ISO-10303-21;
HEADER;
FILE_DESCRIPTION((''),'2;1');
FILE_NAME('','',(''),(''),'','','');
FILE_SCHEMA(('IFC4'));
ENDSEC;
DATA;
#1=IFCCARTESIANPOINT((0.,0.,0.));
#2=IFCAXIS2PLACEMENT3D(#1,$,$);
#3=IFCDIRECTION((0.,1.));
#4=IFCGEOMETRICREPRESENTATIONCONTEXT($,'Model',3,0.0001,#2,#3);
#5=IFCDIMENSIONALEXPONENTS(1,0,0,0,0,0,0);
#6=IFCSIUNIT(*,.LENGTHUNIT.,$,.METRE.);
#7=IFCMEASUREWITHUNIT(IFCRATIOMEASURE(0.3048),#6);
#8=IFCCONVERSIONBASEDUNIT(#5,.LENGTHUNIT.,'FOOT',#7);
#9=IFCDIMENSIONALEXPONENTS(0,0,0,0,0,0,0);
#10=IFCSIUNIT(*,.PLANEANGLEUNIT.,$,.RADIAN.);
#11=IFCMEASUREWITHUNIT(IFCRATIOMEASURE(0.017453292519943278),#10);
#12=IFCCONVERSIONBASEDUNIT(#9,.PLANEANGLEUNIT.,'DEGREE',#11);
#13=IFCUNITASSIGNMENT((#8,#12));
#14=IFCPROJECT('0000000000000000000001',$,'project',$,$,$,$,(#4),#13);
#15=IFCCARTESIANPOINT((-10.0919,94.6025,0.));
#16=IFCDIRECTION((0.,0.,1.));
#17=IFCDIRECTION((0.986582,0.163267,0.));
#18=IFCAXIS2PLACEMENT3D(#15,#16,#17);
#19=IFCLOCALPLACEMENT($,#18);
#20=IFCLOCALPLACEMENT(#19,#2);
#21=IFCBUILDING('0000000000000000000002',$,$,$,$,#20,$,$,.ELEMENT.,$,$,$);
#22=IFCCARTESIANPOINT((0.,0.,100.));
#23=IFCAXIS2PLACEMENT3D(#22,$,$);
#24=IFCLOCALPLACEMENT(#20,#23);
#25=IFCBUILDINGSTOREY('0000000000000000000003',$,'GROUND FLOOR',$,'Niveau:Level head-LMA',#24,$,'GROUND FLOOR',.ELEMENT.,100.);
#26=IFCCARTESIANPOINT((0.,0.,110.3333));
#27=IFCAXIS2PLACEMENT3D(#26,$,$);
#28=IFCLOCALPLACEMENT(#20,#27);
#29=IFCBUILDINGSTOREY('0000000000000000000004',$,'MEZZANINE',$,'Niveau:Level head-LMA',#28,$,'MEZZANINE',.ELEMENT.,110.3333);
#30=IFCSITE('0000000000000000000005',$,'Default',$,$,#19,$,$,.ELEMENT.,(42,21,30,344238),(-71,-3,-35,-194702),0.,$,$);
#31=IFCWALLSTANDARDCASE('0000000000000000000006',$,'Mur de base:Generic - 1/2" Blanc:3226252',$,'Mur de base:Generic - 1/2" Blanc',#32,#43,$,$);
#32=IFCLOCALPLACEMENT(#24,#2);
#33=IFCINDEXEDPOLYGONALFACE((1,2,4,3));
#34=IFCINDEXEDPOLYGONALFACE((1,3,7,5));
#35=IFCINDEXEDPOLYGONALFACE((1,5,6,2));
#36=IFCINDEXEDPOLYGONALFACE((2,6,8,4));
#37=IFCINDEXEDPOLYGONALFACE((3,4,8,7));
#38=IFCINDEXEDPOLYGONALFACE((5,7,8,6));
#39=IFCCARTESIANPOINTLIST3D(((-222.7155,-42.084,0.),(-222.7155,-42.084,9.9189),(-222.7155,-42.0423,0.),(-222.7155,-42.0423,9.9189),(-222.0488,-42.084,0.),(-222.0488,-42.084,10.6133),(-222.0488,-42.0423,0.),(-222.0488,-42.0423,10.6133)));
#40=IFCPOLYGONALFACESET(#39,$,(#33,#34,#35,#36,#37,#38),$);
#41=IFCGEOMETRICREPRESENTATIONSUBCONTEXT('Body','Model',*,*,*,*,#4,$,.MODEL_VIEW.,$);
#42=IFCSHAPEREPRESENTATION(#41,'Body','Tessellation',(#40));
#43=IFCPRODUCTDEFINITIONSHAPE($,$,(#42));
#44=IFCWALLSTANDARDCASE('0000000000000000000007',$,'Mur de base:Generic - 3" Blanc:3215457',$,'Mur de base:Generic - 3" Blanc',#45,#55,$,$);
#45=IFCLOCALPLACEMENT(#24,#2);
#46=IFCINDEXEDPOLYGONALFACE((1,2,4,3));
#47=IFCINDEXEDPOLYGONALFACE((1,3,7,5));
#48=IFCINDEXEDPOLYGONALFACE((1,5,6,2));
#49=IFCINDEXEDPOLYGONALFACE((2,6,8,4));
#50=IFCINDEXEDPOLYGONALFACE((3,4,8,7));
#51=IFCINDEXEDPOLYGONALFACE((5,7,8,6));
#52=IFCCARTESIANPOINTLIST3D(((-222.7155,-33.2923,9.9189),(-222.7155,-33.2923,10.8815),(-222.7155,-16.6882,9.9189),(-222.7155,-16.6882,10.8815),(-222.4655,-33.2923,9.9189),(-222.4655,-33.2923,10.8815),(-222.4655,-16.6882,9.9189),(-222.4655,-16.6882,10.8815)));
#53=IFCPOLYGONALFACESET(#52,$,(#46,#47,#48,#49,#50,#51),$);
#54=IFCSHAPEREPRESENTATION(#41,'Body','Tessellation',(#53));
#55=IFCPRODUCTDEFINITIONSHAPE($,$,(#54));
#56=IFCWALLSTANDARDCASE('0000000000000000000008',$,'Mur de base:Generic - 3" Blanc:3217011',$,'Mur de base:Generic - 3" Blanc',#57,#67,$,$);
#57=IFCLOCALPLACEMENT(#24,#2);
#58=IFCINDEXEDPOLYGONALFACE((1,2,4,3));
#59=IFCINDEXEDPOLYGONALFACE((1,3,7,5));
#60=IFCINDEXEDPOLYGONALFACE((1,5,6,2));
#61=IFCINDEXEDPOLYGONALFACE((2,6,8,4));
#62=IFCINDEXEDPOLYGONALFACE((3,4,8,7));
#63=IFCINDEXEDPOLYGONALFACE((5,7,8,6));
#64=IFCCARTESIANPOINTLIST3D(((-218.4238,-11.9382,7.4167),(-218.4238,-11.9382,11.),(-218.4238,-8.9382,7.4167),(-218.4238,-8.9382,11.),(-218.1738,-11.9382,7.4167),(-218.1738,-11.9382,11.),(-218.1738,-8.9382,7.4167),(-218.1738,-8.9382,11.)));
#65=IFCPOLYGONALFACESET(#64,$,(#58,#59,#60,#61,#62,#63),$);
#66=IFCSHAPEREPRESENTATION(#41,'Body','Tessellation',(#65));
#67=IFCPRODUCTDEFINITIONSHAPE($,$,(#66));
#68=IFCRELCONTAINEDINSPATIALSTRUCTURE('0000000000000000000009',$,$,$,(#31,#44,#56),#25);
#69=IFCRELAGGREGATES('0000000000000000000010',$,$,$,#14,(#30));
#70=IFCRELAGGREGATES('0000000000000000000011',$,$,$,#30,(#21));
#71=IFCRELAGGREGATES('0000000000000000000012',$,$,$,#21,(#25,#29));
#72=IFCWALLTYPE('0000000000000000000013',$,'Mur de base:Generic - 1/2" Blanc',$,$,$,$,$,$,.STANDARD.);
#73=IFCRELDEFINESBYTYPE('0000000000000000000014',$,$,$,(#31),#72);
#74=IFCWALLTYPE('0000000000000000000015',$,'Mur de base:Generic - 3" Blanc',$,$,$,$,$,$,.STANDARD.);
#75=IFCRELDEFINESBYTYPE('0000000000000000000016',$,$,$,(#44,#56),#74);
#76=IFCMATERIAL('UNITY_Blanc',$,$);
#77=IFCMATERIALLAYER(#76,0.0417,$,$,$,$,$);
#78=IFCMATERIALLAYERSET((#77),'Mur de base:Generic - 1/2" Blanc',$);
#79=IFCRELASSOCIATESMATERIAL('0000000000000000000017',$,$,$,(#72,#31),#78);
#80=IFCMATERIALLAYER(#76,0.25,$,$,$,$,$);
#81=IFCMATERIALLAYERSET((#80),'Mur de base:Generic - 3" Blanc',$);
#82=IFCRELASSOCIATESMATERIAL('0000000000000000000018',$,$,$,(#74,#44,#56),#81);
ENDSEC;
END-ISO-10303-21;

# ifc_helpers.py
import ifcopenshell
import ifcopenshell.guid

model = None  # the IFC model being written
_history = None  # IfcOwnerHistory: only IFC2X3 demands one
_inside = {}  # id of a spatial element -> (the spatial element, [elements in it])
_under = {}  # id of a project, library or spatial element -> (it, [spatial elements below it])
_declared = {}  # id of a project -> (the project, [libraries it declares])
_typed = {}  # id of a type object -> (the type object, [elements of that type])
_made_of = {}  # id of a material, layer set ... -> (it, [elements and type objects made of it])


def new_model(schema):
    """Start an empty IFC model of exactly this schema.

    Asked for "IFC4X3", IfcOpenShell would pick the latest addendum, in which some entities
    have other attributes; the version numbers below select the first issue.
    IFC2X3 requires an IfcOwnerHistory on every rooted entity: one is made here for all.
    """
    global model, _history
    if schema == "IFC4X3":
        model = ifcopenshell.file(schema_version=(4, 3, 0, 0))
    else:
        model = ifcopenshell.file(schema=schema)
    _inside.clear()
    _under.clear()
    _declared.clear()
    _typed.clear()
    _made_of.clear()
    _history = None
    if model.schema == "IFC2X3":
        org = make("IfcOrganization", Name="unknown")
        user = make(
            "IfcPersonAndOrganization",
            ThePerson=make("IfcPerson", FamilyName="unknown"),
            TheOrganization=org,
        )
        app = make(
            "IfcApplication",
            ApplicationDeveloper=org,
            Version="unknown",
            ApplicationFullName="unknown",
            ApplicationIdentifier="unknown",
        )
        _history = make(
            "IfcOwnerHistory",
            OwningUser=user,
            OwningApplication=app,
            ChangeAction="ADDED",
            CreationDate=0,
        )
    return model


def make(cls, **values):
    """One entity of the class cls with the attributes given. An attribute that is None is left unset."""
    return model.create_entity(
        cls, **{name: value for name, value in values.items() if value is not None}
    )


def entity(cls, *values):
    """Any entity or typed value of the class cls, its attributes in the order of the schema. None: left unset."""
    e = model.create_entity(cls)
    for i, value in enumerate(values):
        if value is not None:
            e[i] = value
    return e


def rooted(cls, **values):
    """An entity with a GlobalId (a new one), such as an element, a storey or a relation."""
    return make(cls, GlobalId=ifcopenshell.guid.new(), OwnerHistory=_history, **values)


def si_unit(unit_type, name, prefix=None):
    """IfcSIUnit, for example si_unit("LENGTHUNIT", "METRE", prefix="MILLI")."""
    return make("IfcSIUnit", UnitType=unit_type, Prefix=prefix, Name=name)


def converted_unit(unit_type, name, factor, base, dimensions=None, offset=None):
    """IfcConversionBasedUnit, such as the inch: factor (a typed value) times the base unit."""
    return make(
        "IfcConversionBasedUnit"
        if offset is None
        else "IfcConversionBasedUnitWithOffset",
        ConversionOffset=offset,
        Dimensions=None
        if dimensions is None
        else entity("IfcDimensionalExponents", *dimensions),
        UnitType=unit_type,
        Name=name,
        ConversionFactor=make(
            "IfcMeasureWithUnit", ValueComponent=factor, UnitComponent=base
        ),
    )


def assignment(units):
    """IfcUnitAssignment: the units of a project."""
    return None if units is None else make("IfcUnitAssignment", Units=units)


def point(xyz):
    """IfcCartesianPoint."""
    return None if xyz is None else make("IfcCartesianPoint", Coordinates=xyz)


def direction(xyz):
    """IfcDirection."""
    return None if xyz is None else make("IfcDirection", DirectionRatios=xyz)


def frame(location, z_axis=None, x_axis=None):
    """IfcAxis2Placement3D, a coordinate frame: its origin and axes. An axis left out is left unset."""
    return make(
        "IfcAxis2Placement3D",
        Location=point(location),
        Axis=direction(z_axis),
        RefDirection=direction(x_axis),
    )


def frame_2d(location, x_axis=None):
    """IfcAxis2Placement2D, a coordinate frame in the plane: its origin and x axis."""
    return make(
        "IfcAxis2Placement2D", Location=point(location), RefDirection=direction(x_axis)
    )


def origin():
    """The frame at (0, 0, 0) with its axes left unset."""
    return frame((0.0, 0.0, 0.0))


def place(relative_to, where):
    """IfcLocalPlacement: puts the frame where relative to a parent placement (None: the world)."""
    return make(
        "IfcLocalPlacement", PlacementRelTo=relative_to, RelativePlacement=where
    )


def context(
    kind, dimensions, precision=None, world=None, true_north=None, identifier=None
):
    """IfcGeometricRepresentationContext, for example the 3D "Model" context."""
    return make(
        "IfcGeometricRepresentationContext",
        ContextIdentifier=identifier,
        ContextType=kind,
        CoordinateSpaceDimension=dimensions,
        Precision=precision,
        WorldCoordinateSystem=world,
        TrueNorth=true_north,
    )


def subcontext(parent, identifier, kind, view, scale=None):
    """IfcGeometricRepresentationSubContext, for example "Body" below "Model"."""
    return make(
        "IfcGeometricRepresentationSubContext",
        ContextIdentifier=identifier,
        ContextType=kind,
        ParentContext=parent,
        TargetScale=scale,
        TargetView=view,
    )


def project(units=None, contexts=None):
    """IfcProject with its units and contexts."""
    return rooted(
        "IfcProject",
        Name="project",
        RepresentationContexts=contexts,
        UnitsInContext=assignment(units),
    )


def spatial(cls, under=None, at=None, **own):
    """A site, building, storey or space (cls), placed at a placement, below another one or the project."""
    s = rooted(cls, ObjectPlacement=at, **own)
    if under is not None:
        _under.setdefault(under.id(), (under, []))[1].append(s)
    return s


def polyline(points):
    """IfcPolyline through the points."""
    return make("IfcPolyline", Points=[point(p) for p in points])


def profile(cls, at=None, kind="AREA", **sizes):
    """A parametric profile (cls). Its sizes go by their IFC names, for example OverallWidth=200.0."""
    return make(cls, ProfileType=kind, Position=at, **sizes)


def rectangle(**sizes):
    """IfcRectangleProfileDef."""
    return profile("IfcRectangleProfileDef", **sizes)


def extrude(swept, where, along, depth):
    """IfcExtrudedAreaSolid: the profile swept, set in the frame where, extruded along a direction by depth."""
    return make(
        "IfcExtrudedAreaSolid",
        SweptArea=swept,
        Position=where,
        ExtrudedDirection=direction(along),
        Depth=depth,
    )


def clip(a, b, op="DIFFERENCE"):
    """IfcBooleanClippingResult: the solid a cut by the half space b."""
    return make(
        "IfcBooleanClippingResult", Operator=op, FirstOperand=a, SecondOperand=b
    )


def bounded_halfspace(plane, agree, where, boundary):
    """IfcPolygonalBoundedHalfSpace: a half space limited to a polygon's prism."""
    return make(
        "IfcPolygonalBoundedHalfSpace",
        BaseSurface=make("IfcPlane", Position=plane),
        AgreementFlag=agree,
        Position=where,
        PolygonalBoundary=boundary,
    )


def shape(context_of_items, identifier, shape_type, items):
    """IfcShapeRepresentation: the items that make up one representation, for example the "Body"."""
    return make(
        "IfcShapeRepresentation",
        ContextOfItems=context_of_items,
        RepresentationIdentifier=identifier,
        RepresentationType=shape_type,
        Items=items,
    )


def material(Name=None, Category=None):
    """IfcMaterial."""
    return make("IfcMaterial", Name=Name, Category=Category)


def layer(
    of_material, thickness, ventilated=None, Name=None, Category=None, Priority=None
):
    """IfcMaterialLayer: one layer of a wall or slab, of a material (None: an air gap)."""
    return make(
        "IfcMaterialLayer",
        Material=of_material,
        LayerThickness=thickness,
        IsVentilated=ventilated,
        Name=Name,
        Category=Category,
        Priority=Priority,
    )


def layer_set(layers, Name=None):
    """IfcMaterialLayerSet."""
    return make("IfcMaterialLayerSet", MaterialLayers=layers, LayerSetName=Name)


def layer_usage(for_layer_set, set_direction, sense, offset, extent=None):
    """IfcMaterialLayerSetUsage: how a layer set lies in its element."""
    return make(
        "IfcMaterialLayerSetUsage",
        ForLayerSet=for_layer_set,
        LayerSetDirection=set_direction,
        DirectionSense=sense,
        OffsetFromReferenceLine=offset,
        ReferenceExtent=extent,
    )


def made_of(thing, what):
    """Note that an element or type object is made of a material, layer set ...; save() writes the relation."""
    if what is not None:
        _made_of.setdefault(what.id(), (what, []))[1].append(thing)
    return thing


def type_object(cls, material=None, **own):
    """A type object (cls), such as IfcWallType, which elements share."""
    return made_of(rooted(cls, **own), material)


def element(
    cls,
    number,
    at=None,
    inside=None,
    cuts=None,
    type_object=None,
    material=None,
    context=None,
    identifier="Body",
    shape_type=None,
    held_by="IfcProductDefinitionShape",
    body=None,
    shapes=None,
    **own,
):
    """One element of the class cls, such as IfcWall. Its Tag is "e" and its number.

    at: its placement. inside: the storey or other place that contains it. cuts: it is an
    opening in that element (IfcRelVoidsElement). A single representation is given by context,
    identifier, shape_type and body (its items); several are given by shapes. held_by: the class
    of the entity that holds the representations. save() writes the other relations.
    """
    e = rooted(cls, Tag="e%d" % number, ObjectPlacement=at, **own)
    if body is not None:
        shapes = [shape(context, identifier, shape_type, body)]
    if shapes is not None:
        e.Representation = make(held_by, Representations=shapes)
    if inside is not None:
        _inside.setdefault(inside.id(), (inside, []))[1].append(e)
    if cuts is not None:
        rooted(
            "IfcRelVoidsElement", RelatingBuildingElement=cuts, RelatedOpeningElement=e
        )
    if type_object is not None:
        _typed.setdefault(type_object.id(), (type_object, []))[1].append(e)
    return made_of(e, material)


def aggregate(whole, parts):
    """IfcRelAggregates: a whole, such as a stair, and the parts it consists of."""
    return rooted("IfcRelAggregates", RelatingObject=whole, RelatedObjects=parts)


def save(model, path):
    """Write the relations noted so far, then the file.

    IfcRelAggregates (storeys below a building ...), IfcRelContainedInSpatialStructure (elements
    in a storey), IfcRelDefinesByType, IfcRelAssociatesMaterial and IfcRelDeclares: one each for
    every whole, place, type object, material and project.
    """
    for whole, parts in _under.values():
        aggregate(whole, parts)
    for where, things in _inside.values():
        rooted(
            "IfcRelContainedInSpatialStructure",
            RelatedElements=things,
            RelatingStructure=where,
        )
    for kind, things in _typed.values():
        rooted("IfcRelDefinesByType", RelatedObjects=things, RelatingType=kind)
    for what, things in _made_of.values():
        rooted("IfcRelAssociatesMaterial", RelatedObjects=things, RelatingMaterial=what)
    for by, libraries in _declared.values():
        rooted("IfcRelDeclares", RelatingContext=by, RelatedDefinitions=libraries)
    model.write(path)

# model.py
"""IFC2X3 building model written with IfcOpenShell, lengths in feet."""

from ifc_helpers import new_model, entity, si_unit, converted_unit, direction, frame, frame_2d, origin, place, context, subcontext, project, spatial, polyline, rectangle, extrude, clip, bounded_halfspace, material, layer, layer_set, layer_usage, type_object, element, save


model = new_model("IFC2X3")

# Units and contexts
model_context = context("Model", 3, precision=0.0001, world=origin(), true_north=direction((0.0, 1.0)))
body_context = subcontext(model_context, "Body", "Model", "MODEL_VIEW")
ifc_project = project(units=[converted_unit("LENGTHUNIT", "FOOT", entity("IfcRatioMeasure", 0.3048), si_unit("LENGTHUNIT", "METRE"), dimensions=[1, 0, 0, 0, 0, 0, 0]), converted_unit("PLANEANGLEUNIT", "DEGREE", entity("IfcRatioMeasure", 0.017453292519943278), si_unit("PLANEANGLEUNIT", "RADIAN"), dimensions=[0, 0, 0, 0, 0, 0, 0])], contexts=[model_context])

# Site, building, storey
site_placement = place(None, frame((-10.0919, 94.6025, 0.0), z_axis=(0.0, 0.0, 1.0), x_axis=(0.986582, 0.163267, 0.0)))
site = spatial("IfcSite", under=ifc_project, at=site_placement, Name="Default", CompositionType="ELEMENT", RefLatitude=(42, 21, 30, 344238), RefLongitude=(-71, -3, -35, -194702), RefElevation=0.0)
building_placement = place(site_placement, origin())
building = spatial("IfcBuilding", under=site, at=building_placement, CompositionType="ELEMENT")
storey_1_placement = place(building_placement, frame((0.0, 0.0, 100.0)))
storey_1 = spatial("IfcBuildingStorey", under=building, at=storey_1_placement, Name="GROUND FLOOR", ObjectType="Niveau:Level head-LMA", LongName="GROUND FLOOR", CompositionType="ELEMENT", Elevation=100.0)

# Shared definitions
storey_2_placement = place(building_placement, frame((0.0, 0.0, 110.3333)))
storey_2 = spatial("IfcBuildingStorey", under=building, at=storey_2_placement, Name="MEZZANINE", ObjectType="Niveau:Level head-LMA", LongName="MEZZANINE", CompositionType="ELEMENT", Elevation=110.3333)

# Wall
ifc_material_1 = material(Name="UNITY_Blanc")
ifc_layer_1 = layer(ifc_material_1, 0.0417)
ifc_layer_set_1 = layer_set([ifc_layer_1], Name="Mur de base:Generic - 1/2\" Blanc")
ifc_layer_usage_1 = layer_usage(ifc_layer_set_1, "AXIS2", "POSITIVE", -0.0208)
wall_type_1 = type_object("IfcWallType", Name="Mur de base:Generic - 1/2\" Blanc", PredefinedType="STANDARD", material=ifc_layer_set_1)
wall_1_placement = place(storey_1_placement, frame((-222.7155, -42.0632, 0.0)))
element("IfcWallStandardCase", 1, at=wall_1_placement, inside=storey_1, type_object=wall_type_1, material=ifc_layer_usage_1, Name="Mur de base:Generic - 1/2\" Blanc:3226252", ObjectType="Mur de base:Generic - 1/2\" Blanc", context=body_context, shape_type="Clipping", body=[
    clip(extrude(rectangle(XDim=0.6667, YDim=0.0417, at=frame_2d((0.3333, 0.0), x_axis=(-1.0, 0.0))), origin(), (0.0, 0.0, 1.0), 10.6133), bounded_halfspace(frame((0.0, -0.0208, 9.9189), z_axis=(-0.721387, 0.0, 0.692532), x_axis=(0.0, -1.0, 0.0)), False, frame((0.0, -0.0208, 9.9189)), polyline([(0.0, 0.0), (0.6667, 0.0), (0.6667, 0.0417), (0.0417, 0.0417), (0.0, 0.0417), (0.0, 0.0)]))),
])

# Shared definitions
ifc_layer_2 = layer(ifc_material_1, 0.25)
ifc_layer_set_2 = layer_set([ifc_layer_2], Name="Mur de base:Generic - 3\" Blanc")
wall_type_2 = type_object("IfcWallType", Name="Mur de base:Generic - 3\" Blanc", PredefinedType="STANDARD", material=ifc_layer_set_2)

# Walls
ifc_layer_usage_2 = layer_usage(ifc_layer_set_2, "AXIS2", "POSITIVE", -0.125)
wall_2_placement = place(storey_1_placement, frame((-222.5905, -16.6882, 9.9189), z_axis=(0.0, 0.0, 1.0), x_axis=(0.0, -1.0, 0.0)))
element("IfcWallStandardCase", 2, at=wall_2_placement, inside=storey_1, type_object=wall_type_2, material=ifc_layer_usage_2, Name="Mur de base:Generic - 3\" Blanc:3215457", ObjectType="Mur de base:Generic - 3\" Blanc", context=body_context, shape_type="SweptSolid", body=[
    extrude(rectangle(XDim=16.6042, YDim=0.25, at=frame_2d((8.3021, 0.0), x_axis=(-1.0, 0.0))), origin(), (0.0, 0.0, 1.0), 0.9627),
])
ifc_layer_usage_3 = layer_usage(ifc_layer_set_2, "AXIS2", "POSITIVE", -0.125)
wall_3_placement = place(storey_1_placement, frame((-218.2988, -11.9382, 7.4167), z_axis=(0.0, 0.0, 1.0), x_axis=(0.0, 1.0, 0.0)))
element("IfcWallStandardCase", 3, at=wall_3_placement, inside=storey_1, type_object=wall_type_2, material=ifc_layer_usage_3, Name="Mur de base:Generic - 3\" Blanc:3217011", ObjectType="Mur de base:Generic - 3\" Blanc", context=body_context, shape_type="SweptSolid", body=[
    extrude(rectangle(XDim=3.0, YDim=0.25, at=frame_2d((1.5, 0.0), x_axis=(-1.0, 0.0))), origin(), (0.0, 0.0, 1.0), 3.5833),
])

save(model, "model.ifc")
